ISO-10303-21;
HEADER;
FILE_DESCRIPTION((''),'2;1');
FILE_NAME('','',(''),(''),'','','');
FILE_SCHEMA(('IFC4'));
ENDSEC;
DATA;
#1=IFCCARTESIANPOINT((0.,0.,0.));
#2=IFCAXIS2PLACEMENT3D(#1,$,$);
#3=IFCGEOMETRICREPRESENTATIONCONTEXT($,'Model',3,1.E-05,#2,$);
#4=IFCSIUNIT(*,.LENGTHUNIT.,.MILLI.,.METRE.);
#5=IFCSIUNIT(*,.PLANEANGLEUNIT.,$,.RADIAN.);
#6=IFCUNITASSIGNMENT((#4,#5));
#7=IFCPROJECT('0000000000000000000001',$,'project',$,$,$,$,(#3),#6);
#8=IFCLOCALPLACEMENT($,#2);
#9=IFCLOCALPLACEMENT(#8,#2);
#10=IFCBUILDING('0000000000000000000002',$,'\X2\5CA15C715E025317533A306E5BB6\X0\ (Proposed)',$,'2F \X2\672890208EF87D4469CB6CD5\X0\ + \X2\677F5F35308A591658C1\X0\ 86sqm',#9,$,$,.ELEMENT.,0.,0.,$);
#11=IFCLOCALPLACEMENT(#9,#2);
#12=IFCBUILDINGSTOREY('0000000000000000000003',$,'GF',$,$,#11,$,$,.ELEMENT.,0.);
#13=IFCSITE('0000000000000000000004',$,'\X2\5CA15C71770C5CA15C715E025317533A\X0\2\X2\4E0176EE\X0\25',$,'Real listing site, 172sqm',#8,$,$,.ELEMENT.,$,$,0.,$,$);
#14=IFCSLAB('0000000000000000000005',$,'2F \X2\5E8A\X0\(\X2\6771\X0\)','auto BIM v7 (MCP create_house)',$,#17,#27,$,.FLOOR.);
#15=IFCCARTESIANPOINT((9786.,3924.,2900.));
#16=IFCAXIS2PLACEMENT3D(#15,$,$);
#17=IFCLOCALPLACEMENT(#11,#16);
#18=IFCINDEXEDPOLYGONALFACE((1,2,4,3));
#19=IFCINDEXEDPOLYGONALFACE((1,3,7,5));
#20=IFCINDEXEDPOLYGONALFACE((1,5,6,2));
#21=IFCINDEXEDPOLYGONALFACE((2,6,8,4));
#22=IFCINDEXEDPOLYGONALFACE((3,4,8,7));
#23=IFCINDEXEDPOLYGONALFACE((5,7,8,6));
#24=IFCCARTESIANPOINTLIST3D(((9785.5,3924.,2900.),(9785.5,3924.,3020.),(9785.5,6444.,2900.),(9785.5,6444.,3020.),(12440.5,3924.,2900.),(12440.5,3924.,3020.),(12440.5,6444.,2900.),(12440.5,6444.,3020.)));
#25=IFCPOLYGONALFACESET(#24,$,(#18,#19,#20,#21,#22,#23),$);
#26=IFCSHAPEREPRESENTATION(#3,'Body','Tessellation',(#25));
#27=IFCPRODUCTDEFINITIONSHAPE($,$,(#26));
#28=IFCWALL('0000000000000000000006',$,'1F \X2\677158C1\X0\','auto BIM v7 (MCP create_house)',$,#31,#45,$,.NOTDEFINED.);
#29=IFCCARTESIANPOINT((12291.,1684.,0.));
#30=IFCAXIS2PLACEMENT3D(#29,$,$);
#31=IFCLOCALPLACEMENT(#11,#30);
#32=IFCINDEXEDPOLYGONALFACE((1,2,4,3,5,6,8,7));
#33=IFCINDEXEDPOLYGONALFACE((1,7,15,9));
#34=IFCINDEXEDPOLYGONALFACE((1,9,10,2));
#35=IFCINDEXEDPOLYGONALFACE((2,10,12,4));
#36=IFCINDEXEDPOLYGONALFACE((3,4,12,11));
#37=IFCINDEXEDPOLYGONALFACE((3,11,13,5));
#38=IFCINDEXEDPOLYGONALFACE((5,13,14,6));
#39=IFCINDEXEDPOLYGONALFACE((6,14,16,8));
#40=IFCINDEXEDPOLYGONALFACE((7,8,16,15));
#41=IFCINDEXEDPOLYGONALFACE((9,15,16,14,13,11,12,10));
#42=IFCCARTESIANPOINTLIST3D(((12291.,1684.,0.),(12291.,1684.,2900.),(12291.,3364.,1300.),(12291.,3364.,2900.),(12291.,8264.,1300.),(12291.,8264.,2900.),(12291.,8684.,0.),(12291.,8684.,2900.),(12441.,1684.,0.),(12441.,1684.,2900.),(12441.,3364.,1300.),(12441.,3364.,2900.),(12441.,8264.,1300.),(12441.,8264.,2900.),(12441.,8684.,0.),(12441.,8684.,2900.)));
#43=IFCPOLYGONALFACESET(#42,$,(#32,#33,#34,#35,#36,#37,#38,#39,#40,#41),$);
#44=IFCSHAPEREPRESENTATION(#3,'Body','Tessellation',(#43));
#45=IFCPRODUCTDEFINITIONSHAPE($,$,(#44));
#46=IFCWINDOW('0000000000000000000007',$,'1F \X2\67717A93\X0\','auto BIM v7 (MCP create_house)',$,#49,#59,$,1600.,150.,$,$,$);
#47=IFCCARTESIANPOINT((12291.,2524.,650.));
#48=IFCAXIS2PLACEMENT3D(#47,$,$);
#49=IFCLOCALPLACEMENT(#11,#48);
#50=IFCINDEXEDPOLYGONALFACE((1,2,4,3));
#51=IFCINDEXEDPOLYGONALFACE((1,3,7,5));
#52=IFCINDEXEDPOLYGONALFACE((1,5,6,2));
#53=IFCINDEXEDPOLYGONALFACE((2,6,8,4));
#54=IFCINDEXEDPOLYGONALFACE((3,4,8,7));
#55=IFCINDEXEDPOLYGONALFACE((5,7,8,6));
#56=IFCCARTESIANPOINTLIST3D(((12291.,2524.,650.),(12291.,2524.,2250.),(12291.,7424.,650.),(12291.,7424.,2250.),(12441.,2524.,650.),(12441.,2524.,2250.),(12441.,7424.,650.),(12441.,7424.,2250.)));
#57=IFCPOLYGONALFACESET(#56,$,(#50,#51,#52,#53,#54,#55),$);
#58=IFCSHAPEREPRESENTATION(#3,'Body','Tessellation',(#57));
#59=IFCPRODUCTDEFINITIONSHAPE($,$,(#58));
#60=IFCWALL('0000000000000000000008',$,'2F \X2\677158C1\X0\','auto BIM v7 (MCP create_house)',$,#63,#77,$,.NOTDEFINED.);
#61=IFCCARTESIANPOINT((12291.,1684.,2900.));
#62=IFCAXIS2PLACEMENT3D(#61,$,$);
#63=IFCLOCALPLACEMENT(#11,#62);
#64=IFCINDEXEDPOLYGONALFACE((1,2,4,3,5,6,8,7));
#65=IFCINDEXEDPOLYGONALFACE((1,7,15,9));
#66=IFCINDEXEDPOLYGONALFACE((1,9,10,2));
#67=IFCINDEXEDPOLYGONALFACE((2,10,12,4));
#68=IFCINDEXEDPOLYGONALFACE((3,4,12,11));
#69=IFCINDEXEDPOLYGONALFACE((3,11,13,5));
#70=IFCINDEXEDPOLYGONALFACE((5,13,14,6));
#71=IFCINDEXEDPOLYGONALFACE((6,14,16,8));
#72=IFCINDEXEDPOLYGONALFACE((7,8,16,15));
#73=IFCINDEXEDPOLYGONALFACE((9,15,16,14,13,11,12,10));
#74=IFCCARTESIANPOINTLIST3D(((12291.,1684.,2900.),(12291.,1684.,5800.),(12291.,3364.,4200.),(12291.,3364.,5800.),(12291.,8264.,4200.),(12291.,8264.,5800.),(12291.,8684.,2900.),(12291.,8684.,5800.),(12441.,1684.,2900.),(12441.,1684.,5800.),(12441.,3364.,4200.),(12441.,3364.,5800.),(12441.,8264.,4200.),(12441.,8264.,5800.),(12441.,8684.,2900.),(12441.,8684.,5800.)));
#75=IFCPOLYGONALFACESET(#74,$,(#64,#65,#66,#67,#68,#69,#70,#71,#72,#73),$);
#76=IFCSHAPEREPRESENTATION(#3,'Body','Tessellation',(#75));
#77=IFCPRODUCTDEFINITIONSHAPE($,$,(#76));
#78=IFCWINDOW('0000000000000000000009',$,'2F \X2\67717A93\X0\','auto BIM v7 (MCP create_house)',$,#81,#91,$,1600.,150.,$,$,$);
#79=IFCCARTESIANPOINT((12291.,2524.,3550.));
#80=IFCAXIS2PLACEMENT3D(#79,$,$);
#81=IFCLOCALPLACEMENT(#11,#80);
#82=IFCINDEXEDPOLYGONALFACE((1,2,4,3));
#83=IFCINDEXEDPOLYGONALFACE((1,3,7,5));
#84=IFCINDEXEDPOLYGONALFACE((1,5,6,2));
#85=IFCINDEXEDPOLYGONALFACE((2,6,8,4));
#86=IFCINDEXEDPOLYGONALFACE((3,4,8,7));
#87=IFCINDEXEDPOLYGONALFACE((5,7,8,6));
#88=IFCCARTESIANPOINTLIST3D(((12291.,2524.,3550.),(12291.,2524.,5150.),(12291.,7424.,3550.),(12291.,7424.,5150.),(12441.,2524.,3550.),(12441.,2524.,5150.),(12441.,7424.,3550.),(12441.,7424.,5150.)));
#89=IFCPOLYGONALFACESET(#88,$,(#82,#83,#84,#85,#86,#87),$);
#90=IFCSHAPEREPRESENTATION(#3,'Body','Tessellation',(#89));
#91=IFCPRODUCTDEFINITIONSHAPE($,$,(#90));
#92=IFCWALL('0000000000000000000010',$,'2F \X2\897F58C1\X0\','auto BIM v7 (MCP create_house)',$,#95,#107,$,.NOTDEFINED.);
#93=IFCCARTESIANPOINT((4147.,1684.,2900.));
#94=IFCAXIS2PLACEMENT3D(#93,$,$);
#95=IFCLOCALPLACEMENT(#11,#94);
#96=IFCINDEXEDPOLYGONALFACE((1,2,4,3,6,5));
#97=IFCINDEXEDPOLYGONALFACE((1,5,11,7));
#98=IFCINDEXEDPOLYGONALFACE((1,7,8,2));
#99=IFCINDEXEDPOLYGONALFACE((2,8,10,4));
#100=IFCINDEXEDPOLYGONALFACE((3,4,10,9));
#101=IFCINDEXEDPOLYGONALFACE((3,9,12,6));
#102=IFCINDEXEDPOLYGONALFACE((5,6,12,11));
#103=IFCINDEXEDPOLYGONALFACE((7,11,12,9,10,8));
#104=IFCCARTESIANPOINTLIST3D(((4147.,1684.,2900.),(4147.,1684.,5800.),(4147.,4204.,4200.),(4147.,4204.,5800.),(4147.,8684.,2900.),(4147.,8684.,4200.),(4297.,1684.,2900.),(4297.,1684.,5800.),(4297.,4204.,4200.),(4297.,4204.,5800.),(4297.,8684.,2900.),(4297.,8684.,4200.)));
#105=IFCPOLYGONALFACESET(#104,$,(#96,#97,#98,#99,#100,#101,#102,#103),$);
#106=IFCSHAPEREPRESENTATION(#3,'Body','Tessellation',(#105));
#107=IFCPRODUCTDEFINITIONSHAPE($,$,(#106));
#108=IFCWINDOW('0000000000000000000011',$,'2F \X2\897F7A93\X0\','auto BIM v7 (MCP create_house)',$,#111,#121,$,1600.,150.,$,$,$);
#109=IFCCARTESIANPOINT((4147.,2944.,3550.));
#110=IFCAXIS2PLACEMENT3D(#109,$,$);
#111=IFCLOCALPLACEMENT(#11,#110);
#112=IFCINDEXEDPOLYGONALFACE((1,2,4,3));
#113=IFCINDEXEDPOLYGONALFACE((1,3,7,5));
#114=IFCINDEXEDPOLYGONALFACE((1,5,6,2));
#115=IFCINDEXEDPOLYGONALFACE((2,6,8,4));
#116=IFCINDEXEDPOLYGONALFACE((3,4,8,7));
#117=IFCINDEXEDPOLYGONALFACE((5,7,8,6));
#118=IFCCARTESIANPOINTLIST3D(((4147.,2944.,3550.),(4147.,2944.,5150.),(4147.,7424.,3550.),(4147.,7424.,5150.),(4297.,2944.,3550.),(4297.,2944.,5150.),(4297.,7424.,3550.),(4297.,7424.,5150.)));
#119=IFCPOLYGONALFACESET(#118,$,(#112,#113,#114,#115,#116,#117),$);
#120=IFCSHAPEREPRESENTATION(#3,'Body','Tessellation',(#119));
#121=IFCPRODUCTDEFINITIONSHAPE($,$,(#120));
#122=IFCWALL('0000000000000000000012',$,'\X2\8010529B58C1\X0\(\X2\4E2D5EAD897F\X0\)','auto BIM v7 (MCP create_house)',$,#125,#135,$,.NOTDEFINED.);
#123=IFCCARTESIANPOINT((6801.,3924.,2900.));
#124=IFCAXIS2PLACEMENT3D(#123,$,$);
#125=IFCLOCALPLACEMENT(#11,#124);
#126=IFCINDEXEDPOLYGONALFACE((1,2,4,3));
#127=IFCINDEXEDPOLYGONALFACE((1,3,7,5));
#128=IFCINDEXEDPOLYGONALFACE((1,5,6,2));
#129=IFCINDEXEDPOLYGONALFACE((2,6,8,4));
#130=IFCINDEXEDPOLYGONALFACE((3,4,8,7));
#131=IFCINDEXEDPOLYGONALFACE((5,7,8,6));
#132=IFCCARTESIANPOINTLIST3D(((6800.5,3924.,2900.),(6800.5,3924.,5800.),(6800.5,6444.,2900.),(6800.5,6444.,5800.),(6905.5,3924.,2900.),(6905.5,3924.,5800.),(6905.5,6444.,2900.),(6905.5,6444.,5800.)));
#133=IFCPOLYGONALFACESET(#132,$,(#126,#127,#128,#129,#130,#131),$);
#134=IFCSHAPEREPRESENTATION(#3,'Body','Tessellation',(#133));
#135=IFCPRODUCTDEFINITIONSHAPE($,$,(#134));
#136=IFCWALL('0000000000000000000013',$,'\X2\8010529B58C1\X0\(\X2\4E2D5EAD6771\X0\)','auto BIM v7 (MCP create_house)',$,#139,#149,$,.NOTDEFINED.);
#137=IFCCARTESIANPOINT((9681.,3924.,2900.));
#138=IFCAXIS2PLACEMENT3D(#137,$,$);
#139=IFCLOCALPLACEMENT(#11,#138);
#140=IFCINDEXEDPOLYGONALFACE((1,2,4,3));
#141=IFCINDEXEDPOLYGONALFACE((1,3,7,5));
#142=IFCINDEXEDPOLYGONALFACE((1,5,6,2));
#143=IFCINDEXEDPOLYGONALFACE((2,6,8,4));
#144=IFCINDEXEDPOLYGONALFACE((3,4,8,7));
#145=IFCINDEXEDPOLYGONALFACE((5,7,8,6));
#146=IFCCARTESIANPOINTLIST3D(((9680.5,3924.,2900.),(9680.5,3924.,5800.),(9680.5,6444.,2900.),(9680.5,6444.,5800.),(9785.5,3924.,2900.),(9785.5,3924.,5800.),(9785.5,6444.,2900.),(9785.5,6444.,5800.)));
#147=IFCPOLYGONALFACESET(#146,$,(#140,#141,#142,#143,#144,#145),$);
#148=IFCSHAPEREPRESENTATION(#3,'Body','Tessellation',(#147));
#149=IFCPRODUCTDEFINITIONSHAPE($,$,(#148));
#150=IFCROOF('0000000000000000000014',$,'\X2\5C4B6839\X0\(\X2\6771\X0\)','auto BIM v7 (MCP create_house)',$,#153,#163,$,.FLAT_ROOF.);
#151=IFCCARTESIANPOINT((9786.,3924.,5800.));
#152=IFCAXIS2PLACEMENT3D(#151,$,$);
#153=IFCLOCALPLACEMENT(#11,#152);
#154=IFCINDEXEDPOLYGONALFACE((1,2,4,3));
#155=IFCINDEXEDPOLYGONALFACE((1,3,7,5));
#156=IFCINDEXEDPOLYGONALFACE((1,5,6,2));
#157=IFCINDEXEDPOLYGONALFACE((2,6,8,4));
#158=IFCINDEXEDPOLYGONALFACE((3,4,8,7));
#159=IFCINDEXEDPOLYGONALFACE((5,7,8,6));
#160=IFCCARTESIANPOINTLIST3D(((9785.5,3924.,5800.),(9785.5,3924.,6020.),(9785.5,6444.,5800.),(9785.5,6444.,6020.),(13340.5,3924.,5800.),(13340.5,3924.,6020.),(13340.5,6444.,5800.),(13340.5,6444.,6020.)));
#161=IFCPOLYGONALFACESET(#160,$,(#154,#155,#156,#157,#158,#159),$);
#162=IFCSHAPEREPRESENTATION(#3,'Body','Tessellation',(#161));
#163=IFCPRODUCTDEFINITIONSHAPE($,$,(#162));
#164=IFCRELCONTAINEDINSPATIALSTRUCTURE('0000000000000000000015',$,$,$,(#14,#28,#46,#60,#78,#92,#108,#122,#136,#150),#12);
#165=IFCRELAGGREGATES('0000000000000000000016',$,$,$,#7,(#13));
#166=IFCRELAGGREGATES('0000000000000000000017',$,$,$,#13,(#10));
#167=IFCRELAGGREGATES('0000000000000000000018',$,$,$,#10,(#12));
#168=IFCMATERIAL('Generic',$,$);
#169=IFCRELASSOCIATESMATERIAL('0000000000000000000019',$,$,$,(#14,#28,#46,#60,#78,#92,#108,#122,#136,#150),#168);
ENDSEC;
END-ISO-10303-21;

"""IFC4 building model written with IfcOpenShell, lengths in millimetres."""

from ifc_helpers import new_model, si_unit, frame, frame_2d, origin, place, context, project, spatial, rectangle, extrude, material, element, fill, save


model = new_model("IFC4")

# Units and contexts
model_context = context("Model", 3, precision=1e-05, world=origin())
ifc_project = project(units=[si_unit("LENGTHUNIT", "METRE", prefix="MILLI"), si_unit("PLANEANGLEUNIT", "RADIAN")], contexts=[model_context])

# Site, building, storey
site_placement = place(None, origin())
site = spatial("IfcSite", under=ifc_project, at=site_placement, Name="岡山県岡山市北区2丁目25", ObjectType="Real listing site, 172sqm", CompositionType="ELEMENT", RefElevation=0.0)
building_placement = place(site_placement, origin())
building = spatial("IfcBuilding", under=site, at=building_placement, Name="岡山市北区の家 (Proposed)", ObjectType="2F 木造軸組構法 + 板張り外壁 86sqm", CompositionType="ELEMENT", ElevationOfRefHeight=0.0, ElevationOfTerrain=0.0)
storey_placement = place(building_placement, origin())
storey = spatial("IfcBuildingStorey", under=building, at=storey_placement, Name="GF", CompositionType="ELEMENT", Elevation=0.0)

# Slab
ifc_material = material(Name="Generic")
slab_1_placement = place(storey_placement, frame((9786.0, 3924.0, 2900.0)))
element("IfcSlab", 1, at=slab_1_placement, inside=storey, material=ifc_material, Name="2F 床(東)", Description="auto BIM v7 (MCP create_house)", PredefinedType="FLOOR", context=model_context, shape_type="SweptSolid", body=[
    extrude(rectangle(XDim=2655.0, YDim=2520.0, at=frame_2d((1327.0, 1260.0))), frame((9786.0, 3924.0, 2900.0)), (0.0, 0.0, 1.0), 120.0),
])

# Wall, opening, window
wall_1_placement = place(storey_placement, frame((12291.0, 1684.0, 0.0)))
wall_1 = element("IfcWall", 2, at=wall_1_placement, inside=storey, material=ifc_material, Name="1F 東壁", Description="auto BIM v7 (MCP create_house)", PredefinedType="NOTDEFINED", context=model_context, shape_type="SweptSolid", body=[
    extrude(rectangle(XDim=150.0, YDim=7000.0, at=frame_2d((75.0, 3500.0))), frame((12291.0, 1684.0, 0.0)), (0.0, 0.0, 1.0), 2900.0),
])
opening_1_placement = place(storey_placement, frame((12291.0, 2524.0, 650.0)))
opening_1 = element("IfcOpeningElement", 3, at=opening_1_placement, cuts=wall_1, PredefinedType="NOTDEFINED", context=model_context, shape_type="SweptSolid", body=[
    extrude(rectangle(XDim=150.0, YDim=4900.0, at=frame_2d((75.0, 2450.0))), frame((12291.0, 2524.0, 650.0)), (0.0, 0.0, 1.0), 1600.0),
])
window_1_placement = place(storey_placement, frame((12291.0, 2524.0, 650.0)))
window_1 = element("IfcWindow", 4, at=window_1_placement, inside=storey, material=ifc_material, Name="1F 東窓", Description="auto BIM v7 (MCP create_house)", OverallHeight=1600.0, OverallWidth=150.0, context=model_context, shape_type="SweptSolid", body=[
    extrude(rectangle(XDim=150.0, YDim=4900.0, at=frame_2d((75.0, 2450.0))), frame((12291.0, 2524.0, 650.0)), (0.0, 0.0, 1.0), 1600.0),
])
fill(opening_1, window_1)

# Walls, openings, windows
wall_2_placement = place(storey_placement, frame((12291.0, 1684.0, 2900.0)))
wall_2 = element("IfcWall", 5, at=wall_2_placement, inside=storey, material=ifc_material, Name="2F 東壁", Description="auto BIM v7 (MCP create_house)", PredefinedType="NOTDEFINED", context=model_context, shape_type="SweptSolid", body=[
    extrude(rectangle(XDim=150.0, YDim=7000.0, at=frame_2d((75.0, 3500.0))), frame((12291.0, 1684.0, 2900.0)), (0.0, 0.0, 1.0), 2900.0),
])
opening_2_placement = place(storey_placement, frame((12291.0, 2524.0, 3550.0)))
opening_2 = element("IfcOpeningElement", 6, at=opening_2_placement, cuts=wall_2, PredefinedType="NOTDEFINED", context=model_context, shape_type="SweptSolid", body=[
    extrude(rectangle(XDim=150.0, YDim=4900.0, at=frame_2d((75.0, 2450.0))), frame((12291.0, 2524.0, 3550.0)), (0.0, 0.0, 1.0), 1600.0),
])
window_2_placement = place(storey_placement, frame((12291.0, 2524.0, 3550.0)))
window_2 = element("IfcWindow", 7, at=window_2_placement, inside=storey, material=ifc_material, Name="2F 東窓", Description="auto BIM v7 (MCP create_house)", OverallHeight=1600.0, OverallWidth=150.0, context=model_context, shape_type="SweptSolid", body=[
    extrude(rectangle(XDim=150.0, YDim=4900.0, at=frame_2d((75.0, 2450.0))), frame((12291.0, 2524.0, 3550.0)), (0.0, 0.0, 1.0), 1600.0),
])
fill(opening_2, window_2)
wall_3_placement = place(storey_placement, frame((4147.0, 1684.0, 2900.0)))
wall_3 = element("IfcWall", 8, at=wall_3_placement, inside=storey, material=ifc_material, Name="2F 西壁", Description="auto BIM v7 (MCP create_house)", PredefinedType="NOTDEFINED", context=model_context, shape_type="SweptSolid", body=[
    extrude(rectangle(XDim=150.0, YDim=7000.0, at=frame_2d((75.0, 3500.0))), frame((4147.0, 1684.0, 2900.0)), (0.0, 0.0, 1.0), 2900.0),
])
opening_3_placement = place(storey_placement, frame((4147.0, 2944.0, 3550.0)))
opening_3 = element("IfcOpeningElement", 9, at=opening_3_placement, cuts=wall_3, PredefinedType="NOTDEFINED", context=model_context, shape_type="SweptSolid", body=[
    extrude(rectangle(XDim=150.0, YDim=4480.0, at=frame_2d((75.0, 2240.0))), frame((4147.0, 2944.0, 3550.0)), (0.0, 0.0, 1.0), 1600.0),
])
window_3_placement = place(storey_placement, frame((4147.0, 2944.0, 3550.0)))
window_3 = element("IfcWindow", 10, at=window_3_placement, inside=storey, material=ifc_material, Name="2F 西窓", Description="auto BIM v7 (MCP create_house)", OverallHeight=1600.0, OverallWidth=150.0, context=model_context, shape_type="SweptSolid", body=[
    extrude(rectangle(XDim=150.0, YDim=4480.0, at=frame_2d((75.0, 2240.0))), frame((4147.0, 2944.0, 3550.0)), (0.0, 0.0, 1.0), 1600.0),
])
fill(opening_3, window_3)

# Walls
wall_4_placement = place(storey_placement, frame((6801.0, 3924.0, 2900.0)))
element("IfcWall", 11, at=wall_4_placement, inside=storey, material=ifc_material, Name="耐力壁(中庭西)", Description="auto BIM v7 (MCP create_house)", PredefinedType="NOTDEFINED", context=model_context, shape_type="SweptSolid", body=[
    extrude(rectangle(XDim=105.0, YDim=2520.0, at=frame_2d((52.0, 1260.0))), frame((6801.0, 3924.0, 2900.0)), (0.0, 0.0, 1.0), 2900.0),
])
wall_5_placement = place(storey_placement, frame((9681.0, 3924.0, 2900.0)))
element("IfcWall", 12, at=wall_5_placement, inside=storey, material=ifc_material, Name="耐力壁(中庭東)", Description="auto BIM v7 (MCP create_house)", PredefinedType="NOTDEFINED", context=model_context, shape_type="SweptSolid", body=[
    extrude(rectangle(XDim=105.0, YDim=2520.0, at=frame_2d((52.0, 1260.0))), frame((9681.0, 3924.0, 2900.0)), (0.0, 0.0, 1.0), 2900.0),
])

# Roof
for number, where, name in (
    (13, (9786.0, 3924.0, 5800.0), "屋根(東)"),
):
    element("IfcRoof", number, at=place(storey_placement, frame(where)), inside=storey, material=ifc_material, Name=name, Description="auto BIM v7 (MCP create_house)", PredefinedType="FLAT_ROOF", context=model_context, shape_type="SweptSolid", body=[
        extrude(rectangle(XDim=3555.0, YDim=2520.0, at=frame_2d((1777.0, 1260.0))), frame((9786.0, 3924.0, 5800.0)), (0.0, 0.0, 1.0), 220.0),
    ])

save(model, "model.ifc")
